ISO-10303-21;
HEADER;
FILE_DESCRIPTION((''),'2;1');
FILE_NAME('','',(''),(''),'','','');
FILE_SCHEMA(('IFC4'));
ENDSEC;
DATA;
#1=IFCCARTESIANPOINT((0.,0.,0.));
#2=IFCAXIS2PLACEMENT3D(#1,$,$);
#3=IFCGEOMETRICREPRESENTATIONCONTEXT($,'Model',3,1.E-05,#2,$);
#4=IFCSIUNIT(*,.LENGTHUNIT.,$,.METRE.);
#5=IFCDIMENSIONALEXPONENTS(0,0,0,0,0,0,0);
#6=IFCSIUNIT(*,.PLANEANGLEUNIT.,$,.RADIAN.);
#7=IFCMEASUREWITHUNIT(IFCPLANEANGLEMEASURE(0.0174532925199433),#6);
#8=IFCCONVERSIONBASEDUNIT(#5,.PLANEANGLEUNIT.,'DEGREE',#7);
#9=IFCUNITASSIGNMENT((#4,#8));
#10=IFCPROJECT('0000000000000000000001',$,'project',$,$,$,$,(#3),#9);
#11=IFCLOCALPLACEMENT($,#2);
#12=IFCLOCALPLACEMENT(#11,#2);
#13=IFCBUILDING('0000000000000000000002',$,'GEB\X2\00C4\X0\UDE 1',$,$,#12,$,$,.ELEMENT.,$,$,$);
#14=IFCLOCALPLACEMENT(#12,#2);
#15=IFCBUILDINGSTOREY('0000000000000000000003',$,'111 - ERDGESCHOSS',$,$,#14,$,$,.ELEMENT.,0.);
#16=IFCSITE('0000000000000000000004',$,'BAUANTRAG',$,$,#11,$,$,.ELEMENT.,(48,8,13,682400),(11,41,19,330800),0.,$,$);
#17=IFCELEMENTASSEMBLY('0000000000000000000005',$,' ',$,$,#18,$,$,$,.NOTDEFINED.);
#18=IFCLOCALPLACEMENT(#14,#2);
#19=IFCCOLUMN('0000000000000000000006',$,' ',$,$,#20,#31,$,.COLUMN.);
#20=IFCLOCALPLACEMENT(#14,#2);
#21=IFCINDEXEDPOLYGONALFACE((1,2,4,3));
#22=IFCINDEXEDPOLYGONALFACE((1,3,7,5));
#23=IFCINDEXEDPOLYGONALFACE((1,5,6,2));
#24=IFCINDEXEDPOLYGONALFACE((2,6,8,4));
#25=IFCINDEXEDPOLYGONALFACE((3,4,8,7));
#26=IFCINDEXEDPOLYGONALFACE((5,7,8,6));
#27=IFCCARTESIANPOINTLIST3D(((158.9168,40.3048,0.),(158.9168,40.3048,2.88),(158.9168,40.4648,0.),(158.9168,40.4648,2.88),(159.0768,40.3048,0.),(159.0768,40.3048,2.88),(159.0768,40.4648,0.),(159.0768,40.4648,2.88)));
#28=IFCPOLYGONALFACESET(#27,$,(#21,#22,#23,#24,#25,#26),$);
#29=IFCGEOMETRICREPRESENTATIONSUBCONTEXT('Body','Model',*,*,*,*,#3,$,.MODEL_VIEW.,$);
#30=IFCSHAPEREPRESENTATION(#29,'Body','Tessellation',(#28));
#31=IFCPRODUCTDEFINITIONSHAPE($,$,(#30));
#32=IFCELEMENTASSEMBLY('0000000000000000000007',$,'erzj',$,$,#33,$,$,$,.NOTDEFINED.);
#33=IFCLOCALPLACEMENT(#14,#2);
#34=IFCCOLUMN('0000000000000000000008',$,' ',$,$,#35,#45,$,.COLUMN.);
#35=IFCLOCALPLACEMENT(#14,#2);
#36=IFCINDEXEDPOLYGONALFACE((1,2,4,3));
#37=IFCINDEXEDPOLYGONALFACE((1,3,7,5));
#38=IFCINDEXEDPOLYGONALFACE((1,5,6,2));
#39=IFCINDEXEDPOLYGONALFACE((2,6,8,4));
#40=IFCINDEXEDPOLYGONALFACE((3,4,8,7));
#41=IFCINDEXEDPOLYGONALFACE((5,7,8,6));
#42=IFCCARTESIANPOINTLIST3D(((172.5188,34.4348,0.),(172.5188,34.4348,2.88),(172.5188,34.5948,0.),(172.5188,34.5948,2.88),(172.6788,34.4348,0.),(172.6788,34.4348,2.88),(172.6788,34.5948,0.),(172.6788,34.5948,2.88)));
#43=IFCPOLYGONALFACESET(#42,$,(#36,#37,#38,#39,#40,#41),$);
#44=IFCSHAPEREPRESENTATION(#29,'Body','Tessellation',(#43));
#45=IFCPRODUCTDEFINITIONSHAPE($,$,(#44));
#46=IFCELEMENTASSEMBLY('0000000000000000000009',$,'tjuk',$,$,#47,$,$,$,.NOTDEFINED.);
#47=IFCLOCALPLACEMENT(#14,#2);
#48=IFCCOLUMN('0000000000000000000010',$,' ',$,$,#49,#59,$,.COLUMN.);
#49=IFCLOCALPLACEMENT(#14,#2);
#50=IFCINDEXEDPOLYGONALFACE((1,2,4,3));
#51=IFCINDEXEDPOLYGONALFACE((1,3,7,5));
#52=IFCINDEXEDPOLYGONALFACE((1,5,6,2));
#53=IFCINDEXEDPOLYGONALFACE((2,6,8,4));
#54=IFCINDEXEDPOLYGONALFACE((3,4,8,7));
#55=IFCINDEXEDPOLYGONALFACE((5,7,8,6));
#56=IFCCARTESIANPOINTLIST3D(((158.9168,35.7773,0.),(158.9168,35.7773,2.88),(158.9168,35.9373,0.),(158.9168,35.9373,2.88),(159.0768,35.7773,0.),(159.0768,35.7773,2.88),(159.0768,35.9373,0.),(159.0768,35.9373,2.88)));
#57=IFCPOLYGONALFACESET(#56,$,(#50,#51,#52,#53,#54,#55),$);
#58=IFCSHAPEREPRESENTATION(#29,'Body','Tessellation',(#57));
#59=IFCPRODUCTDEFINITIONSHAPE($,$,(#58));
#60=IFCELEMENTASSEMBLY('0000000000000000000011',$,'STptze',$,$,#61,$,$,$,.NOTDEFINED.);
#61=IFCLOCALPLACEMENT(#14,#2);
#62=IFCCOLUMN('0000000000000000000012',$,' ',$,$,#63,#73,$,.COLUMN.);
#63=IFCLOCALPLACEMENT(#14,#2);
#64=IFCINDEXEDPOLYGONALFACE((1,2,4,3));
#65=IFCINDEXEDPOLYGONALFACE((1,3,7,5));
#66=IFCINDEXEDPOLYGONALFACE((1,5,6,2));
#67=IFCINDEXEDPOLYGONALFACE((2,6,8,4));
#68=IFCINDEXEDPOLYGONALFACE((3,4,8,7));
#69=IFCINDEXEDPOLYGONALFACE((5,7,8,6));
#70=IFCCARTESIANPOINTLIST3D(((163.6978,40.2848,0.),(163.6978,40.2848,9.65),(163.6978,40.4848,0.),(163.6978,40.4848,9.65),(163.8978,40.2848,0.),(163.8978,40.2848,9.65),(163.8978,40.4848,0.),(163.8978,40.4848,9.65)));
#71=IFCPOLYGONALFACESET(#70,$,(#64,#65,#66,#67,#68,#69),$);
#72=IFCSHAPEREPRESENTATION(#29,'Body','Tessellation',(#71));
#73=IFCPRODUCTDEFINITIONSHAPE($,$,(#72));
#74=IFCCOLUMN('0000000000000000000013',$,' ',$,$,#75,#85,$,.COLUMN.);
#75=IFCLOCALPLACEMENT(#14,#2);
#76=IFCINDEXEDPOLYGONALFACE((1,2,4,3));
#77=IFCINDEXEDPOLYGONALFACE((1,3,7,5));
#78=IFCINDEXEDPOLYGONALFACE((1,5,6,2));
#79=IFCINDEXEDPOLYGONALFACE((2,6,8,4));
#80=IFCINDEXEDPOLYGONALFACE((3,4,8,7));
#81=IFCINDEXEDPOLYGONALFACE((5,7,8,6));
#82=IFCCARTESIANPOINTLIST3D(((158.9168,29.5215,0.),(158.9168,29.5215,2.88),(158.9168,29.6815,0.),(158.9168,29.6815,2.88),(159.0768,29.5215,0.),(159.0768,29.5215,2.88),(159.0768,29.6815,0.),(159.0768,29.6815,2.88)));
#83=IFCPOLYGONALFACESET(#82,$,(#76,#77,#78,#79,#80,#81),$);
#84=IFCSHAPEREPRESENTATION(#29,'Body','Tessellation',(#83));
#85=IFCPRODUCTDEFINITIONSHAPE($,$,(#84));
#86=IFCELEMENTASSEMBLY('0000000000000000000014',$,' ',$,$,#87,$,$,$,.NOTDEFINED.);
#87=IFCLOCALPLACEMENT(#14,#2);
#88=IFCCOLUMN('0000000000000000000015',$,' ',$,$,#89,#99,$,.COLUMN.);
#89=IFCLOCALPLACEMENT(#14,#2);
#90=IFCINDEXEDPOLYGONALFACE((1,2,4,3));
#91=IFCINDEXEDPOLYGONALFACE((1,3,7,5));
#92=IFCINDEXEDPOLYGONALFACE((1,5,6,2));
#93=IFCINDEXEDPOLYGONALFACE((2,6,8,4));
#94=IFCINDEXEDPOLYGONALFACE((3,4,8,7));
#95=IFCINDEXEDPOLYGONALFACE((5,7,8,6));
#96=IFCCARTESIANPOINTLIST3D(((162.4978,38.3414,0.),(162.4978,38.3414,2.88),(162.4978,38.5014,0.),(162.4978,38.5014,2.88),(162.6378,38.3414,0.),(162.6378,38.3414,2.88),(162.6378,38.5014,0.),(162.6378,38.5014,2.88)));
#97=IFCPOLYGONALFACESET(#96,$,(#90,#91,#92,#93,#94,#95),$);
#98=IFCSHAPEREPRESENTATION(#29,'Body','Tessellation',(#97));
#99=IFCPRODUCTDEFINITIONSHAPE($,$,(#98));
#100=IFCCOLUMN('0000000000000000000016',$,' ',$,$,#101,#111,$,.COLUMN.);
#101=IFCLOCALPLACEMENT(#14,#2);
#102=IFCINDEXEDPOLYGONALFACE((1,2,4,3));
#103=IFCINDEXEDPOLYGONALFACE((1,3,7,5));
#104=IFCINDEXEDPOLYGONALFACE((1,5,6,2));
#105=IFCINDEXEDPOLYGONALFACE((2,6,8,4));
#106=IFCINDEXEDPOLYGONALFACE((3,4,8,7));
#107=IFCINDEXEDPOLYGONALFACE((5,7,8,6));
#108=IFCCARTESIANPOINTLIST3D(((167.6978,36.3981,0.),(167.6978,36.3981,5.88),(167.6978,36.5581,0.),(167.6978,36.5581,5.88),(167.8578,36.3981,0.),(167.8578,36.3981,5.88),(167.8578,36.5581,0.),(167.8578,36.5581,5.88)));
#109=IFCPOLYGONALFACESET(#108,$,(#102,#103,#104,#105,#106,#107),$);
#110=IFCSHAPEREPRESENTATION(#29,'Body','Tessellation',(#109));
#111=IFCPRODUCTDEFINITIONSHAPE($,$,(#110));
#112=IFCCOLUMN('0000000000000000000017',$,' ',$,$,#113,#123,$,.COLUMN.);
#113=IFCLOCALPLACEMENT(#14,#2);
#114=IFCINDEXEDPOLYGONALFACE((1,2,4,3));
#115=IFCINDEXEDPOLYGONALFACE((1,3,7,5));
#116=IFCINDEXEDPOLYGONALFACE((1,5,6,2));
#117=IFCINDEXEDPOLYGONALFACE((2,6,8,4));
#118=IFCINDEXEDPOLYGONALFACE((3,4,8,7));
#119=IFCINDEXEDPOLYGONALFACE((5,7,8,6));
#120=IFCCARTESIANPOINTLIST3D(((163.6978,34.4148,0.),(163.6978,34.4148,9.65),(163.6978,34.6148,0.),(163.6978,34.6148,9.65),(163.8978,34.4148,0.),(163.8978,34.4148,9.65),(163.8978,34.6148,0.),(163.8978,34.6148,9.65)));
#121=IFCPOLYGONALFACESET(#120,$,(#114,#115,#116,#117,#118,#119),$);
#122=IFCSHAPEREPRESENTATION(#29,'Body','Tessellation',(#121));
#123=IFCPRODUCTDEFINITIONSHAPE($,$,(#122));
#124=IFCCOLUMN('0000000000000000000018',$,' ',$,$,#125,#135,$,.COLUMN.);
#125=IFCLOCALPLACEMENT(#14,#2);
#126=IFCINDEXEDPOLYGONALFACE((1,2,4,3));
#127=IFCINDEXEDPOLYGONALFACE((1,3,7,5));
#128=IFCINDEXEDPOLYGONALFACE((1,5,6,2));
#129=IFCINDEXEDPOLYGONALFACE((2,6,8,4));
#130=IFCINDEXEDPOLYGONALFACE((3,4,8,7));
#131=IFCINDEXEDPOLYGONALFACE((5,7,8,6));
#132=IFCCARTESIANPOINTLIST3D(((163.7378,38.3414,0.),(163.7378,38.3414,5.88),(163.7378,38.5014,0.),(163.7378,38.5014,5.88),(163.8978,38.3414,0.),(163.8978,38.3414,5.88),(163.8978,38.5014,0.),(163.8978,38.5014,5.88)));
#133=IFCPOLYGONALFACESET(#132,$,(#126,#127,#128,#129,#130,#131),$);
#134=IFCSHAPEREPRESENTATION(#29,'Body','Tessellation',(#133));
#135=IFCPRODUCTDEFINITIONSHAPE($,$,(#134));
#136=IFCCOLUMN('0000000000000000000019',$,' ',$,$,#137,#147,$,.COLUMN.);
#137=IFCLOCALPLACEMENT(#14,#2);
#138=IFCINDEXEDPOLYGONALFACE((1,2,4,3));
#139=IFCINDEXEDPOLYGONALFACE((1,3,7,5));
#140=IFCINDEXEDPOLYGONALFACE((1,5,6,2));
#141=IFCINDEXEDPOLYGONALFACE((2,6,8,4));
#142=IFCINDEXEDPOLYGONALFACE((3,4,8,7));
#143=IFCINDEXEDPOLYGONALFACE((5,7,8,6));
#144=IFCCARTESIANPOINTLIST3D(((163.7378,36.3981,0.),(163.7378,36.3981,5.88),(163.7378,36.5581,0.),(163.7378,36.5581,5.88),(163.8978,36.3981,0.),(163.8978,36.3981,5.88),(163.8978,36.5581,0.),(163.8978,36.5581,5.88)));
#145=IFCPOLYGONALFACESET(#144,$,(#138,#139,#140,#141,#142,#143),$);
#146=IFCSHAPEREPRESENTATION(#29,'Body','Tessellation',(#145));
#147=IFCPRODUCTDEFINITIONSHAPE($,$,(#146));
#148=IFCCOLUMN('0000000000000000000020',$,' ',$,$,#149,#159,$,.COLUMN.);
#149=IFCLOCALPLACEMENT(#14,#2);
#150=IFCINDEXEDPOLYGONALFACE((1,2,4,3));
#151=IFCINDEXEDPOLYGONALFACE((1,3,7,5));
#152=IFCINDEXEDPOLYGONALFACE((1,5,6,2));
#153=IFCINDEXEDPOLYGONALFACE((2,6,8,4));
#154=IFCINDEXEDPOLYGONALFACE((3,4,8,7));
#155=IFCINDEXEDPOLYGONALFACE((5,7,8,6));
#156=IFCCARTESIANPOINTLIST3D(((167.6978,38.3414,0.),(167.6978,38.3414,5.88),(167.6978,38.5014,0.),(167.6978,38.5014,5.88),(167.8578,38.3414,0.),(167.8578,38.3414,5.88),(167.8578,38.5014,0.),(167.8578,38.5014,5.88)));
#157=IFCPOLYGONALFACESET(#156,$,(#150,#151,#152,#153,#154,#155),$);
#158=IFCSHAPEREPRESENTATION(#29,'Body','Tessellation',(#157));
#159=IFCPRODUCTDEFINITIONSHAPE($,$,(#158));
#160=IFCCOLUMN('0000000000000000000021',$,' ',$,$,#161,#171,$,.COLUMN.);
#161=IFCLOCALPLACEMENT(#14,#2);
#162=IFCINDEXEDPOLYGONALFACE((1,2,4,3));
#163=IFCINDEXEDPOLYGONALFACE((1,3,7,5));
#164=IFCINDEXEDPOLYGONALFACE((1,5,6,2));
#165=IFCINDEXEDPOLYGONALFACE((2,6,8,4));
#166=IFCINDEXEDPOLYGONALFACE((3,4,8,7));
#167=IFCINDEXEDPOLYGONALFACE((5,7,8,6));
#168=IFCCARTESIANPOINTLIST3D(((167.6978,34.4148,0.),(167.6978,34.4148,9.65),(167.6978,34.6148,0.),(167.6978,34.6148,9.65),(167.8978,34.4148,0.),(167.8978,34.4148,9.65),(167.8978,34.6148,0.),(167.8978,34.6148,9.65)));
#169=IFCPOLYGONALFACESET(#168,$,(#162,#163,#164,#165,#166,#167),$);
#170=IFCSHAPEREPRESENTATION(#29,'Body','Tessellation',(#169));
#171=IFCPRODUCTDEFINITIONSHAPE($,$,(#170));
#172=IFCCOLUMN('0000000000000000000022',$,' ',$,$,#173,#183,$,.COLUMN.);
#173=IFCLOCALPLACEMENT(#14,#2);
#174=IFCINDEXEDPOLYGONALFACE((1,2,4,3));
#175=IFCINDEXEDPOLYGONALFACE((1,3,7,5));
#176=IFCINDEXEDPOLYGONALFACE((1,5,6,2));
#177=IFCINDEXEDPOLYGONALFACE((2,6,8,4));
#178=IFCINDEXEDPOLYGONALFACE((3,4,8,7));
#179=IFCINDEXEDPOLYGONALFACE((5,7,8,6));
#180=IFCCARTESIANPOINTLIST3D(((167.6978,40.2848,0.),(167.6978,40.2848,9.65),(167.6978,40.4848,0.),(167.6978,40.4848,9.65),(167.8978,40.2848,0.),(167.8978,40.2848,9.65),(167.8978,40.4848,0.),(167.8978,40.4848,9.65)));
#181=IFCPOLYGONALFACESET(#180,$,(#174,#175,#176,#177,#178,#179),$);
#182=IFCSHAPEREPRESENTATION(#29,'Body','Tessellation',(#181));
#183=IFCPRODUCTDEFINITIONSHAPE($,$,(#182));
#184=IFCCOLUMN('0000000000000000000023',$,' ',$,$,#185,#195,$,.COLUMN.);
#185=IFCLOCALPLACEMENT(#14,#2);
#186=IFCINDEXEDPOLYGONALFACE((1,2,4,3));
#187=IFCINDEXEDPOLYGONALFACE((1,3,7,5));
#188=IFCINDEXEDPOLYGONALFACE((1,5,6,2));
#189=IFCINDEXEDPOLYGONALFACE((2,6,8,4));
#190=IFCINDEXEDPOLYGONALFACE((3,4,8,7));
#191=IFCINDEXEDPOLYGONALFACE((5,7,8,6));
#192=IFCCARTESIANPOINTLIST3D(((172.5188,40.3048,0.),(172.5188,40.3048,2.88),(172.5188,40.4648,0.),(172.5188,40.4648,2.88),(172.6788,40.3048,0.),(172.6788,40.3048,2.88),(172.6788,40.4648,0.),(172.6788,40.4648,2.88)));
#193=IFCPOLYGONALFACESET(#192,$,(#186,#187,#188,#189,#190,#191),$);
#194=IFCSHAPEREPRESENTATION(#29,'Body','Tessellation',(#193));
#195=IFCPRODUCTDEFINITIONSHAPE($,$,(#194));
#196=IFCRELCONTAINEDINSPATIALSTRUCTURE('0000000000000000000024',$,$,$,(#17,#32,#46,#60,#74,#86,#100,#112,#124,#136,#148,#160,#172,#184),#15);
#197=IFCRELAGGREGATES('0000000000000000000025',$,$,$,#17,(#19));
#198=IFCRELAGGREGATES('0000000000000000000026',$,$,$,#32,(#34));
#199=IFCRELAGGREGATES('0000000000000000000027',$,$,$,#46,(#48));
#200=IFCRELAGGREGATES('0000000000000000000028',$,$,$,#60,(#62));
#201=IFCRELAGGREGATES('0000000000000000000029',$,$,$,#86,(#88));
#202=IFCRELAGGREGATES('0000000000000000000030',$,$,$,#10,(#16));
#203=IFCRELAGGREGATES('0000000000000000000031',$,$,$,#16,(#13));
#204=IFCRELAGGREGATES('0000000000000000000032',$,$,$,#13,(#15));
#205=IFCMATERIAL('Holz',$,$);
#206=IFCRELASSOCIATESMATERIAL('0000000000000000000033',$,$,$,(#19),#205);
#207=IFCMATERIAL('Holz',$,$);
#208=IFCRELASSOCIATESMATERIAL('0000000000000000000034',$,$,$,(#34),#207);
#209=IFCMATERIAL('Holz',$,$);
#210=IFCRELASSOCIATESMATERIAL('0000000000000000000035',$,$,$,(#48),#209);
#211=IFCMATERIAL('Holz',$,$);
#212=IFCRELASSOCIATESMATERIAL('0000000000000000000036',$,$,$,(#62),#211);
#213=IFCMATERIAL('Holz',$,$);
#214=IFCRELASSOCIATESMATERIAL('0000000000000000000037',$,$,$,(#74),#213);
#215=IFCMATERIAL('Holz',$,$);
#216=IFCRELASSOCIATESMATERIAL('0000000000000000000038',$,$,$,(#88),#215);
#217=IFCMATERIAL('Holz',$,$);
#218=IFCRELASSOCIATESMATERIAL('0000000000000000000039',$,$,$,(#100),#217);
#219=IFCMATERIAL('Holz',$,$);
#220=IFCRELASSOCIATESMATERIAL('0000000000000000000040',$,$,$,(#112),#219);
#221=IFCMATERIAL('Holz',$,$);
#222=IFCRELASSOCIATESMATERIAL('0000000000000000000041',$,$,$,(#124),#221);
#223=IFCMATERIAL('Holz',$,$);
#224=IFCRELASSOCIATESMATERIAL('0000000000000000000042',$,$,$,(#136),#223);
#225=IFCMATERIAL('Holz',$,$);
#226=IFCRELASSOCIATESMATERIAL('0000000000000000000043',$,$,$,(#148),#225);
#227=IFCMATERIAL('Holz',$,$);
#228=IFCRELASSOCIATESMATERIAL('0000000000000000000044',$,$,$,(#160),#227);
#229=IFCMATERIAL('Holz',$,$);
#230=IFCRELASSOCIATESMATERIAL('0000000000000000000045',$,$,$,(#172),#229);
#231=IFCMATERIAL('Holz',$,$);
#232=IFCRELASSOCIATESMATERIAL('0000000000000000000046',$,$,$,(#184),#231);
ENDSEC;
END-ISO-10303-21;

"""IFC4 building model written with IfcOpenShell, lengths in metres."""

from ifc_helpers import new_model, entity, si_unit, converted_unit, frame, origin, origin_with_axes, place, context, subcontext, project, spatial, indexed_curve, outline, extrude, material, element, aggregate, save


model = new_model("IFC4")

# Units and contexts
model_context = context("Model", 3, precision=1e-05, world=origin())
body_context = subcontext(model_context, "Body", "Model", "MODEL_VIEW")
ifc_project = project(units=[si_unit("LENGTHUNIT", "METRE"), converted_unit("PLANEANGLEUNIT", "DEGREE", entity("IfcPlaneAngleMeasure", 0.0174532925199433), si_unit("PLANEANGLEUNIT", "RADIAN"), dimensions=[0, 0, 0, 0, 0, 0, 0])], contexts=[model_context])

# Site, building, storey
site_placement = place(None, origin())
site = spatial("IfcSite", under=ifc_project, at=site_placement, Name="BAUANTRAG", CompositionType="ELEMENT", RefLatitude=(48, 8, 13, 682400), RefLongitude=(11, 41, 19, 330800), RefElevation=0.0)
building_placement = place(site_placement, origin())
building = spatial("IfcBuilding", under=site, at=building_placement, Name="GEBÄUDE 1", CompositionType="ELEMENT")
storey_placement = place(building_placement, origin())
storey = spatial("IfcBuildingStorey", under=building, at=storey_placement, Name="111 - ERDGESCHOSS", CompositionType="ELEMENT", Elevation=0.0)

# Element assemblies, columns
assembly_1_placement = place(storey_placement, origin())
assembly_1 = element("IfcElementAssembly", 1, at=assembly_1_placement, inside=storey, Name=" ", PredefinedType="NOTDEFINED")
ifc_material_1 = material(Name="Holz")
column_1_placement = place(assembly_1_placement, frame((158.9168, 40.3048, 0.0)))
column_1 = element("IfcColumn", 2, at=column_1_placement, material=ifc_material_1, Name=" ", PredefinedType="COLUMN", context=body_context, shape_type="SweptSolid", body=[
    extrude(outline(indexed_curve([(0.0, 0.0), (0.16, 0.0), (0.16, 0.16), (0.0, 0.16), (0.0, 0.0)], self_intersect=False)), origin_with_axes(), (0.0, 0.0, 1.0), 2.88),
])
aggregate(assembly_1, [column_1])
assembly_2_placement = place(storey_placement, origin())
assembly_2 = element("IfcElementAssembly", 3, at=assembly_2_placement, inside=storey, Name="erzj", PredefinedType="NOTDEFINED")
ifc_material_2 = material(Name="Holz")
column_2_placement = place(assembly_2_placement, frame((172.5188, 34.4348, 0.0)))
column_2 = element("IfcColumn", 4, at=column_2_placement, material=ifc_material_2, Name=" ", PredefinedType="COLUMN", context=body_context, shape_type="SweptSolid", body=[
    extrude(outline(indexed_curve([(0.0, 0.0), (0.16, 0.0), (0.16, 0.16), (0.0, 0.16), (0.0, 0.0)], self_intersect=False)), origin_with_axes(), (0.0, 0.0, 1.0), 2.88),
])
aggregate(assembly_2, [column_2])
assembly_3_placement = place(storey_placement, origin())
assembly_3 = element("IfcElementAssembly", 5, at=assembly_3_placement, inside=storey, Name="tjuk", PredefinedType="NOTDEFINED")
ifc_material_3 = material(Name="Holz")
column_3_placement = place(assembly_3_placement, frame((158.9168, 35.7773, 0.0)))
column_3 = element("IfcColumn", 6, at=column_3_placement, material=ifc_material_3, Name=" ", PredefinedType="COLUMN", context=body_context, shape_type="SweptSolid", body=[
    extrude(outline(indexed_curve([(0.0, 0.0), (0.16, 0.0), (0.16, 0.16), (0.0, 0.16), (0.0, 0.0)], self_intersect=False)), origin_with_axes(), (0.0, 0.0, 1.0), 2.88),
])
aggregate(assembly_3, [column_3])
assembly_4_placement = place(storey_placement, origin())
assembly_4 = element("IfcElementAssembly", 7, at=assembly_4_placement, inside=storey, Name="STptze", PredefinedType="NOTDEFINED")
ifc_material_4 = material(Name="Holz")
column_4_placement = place(assembly_4_placement, frame((163.6978, 40.2848, 0.0)))
column_4 = element("IfcColumn", 8, at=column_4_placement, material=ifc_material_4, Name=" ", PredefinedType="COLUMN", context=body_context, shape_type="SweptSolid", body=[
    extrude(outline(indexed_curve([(0.0, 0.0), (0.2, 0.0), (0.2, 0.2), (0.0, 0.2), (0.0, 0.0)], self_intersect=False)), origin_with_axes(), (0.0, 0.0, 1.0), 9.65),
])
aggregate(assembly_4, [column_4])

# Column
ifc_material_5 = material(Name="Holz")
column_5_placement = place(storey_placement, frame((158.9168, 29.5215, 0.0)))
element("IfcColumn", 9, at=column_5_placement, inside=storey, material=ifc_material_5, Name=" ", PredefinedType="COLUMN", context=body_context, shape_type="SweptSolid", body=[
    extrude(outline(indexed_curve([(0.0, 0.0), (0.16, 0.0), (0.16, 0.16), (0.0, 0.16), (0.0, 0.0)], self_intersect=False)), origin_with_axes(), (0.0, 0.0, 1.0), 2.88),
])

# Element assembly, column
assembly_5_placement = place(storey_placement, origin())
assembly_5 = element("IfcElementAssembly", 10, at=assembly_5_placement, inside=storey, Name=" ", PredefinedType="NOTDEFINED")
ifc_material_6 = material(Name="Holz")
column_6_placement = place(assembly_5_placement, frame((162.4978, 38.3414, 0.0)))
column_6 = element("IfcColumn", 11, at=column_6_placement, material=ifc_material_6, Name=" ", PredefinedType="COLUMN", context=body_context, shape_type="SweptSolid", body=[
    extrude(outline(indexed_curve([(0.14, 0.0), (0.14, 0.16), (0.0, 0.16), (0.0, 0.0), (0.14, 0.0)], self_intersect=False)), origin_with_axes(), (0.0, 0.0, 1.0), 2.88),
])
aggregate(assembly_5, [column_6])

# Columns
ifc_material_7 = material(Name="Holz")
column_7_placement = place(storey_placement, frame((167.6978, 36.3981, 0.0)))
element("IfcColumn", 12, at=column_7_placement, inside=storey, material=ifc_material_7, Name=" ", PredefinedType="COLUMN", context=body_context, shape_type="SweptSolid", body=[
    extrude(outline(indexed_curve([(0.0, 0.0), (0.16, 0.0), (0.16, 0.16), (0.0, 0.16), (0.0, 0.0)], self_intersect=False)), origin_with_axes(), (0.0, 0.0, 1.0), 5.88),
])
ifc_material_8 = material(Name="Holz")
column_8_placement = place(storey_placement, frame((163.6978, 34.4148, 0.0)))
element("IfcColumn", 13, at=column_8_placement, inside=storey, material=ifc_material_8, Name=" ", PredefinedType="COLUMN", context=body_context, shape_type="SweptSolid", body=[
    extrude(outline(indexed_curve([(0.0, 0.0), (0.2, 0.0), (0.2, 0.2), (0.0, 0.2), (0.0, 0.0)], self_intersect=False)), origin_with_axes(), (0.0, 0.0, 1.0), 9.65),
])
ifc_material_9 = material(Name="Holz")
column_9_placement = place(storey_placement, frame((163.7378, 38.3414, 0.0)))
element("IfcColumn", 14, at=column_9_placement, inside=storey, material=ifc_material_9, Name=" ", PredefinedType="COLUMN", context=body_context, shape_type="SweptSolid", body=[
    extrude(outline(indexed_curve([(0.0, 0.0), (0.16, 0.0), (0.16, 0.16), (0.0, 0.16), (0.0, 0.0)], self_intersect=False)), origin_with_axes(), (0.0, 0.0, 1.0), 5.88),
])
ifc_material_10 = material(Name="Holz")
column_10_placement = place(storey_placement, frame((163.7378, 36.3981, 0.0)))
element("IfcColumn", 15, at=column_10_placement, inside=storey, material=ifc_material_10, Name=" ", PredefinedType="COLUMN", context=body_context, shape_type="SweptSolid", body=[
    extrude(outline(indexed_curve([(0.0, 0.0), (0.16, 0.0), (0.16, 0.16), (0.0, 0.16), (0.0, 0.0)], self_intersect=False)), origin_with_axes(), (0.0, 0.0, 1.0), 5.88),
])
ifc_material_11 = material(Name="Holz")
column_11_placement = place(storey_placement, frame((167.6978, 38.3414, 0.0)))
element("IfcColumn", 16, at=column_11_placement, inside=storey, material=ifc_material_11, Name=" ", PredefinedType="COLUMN", context=body_context, shape_type="SweptSolid", body=[
    extrude(outline(indexed_curve([(0.0, 0.0), (0.16, 0.0), (0.16, 0.16), (0.0, 0.16), (0.0, 0.0)], self_intersect=False)), origin_with_axes(), (0.0, 0.0, 1.0), 5.88),
])
ifc_material_12 = material(Name="Holz")
column_12_placement = place(storey_placement, frame((167.6978, 34.4148, 0.0)))
element("IfcColumn", 17, at=column_12_placement, inside=storey, material=ifc_material_12, Name=" ", PredefinedType="COLUMN", context=body_context, shape_type="SweptSolid", body=[
    extrude(outline(indexed_curve([(0.0, 0.0), (0.2, 0.0), (0.2, 0.2), (0.0, 0.2), (0.0, 0.0)], self_intersect=False)), origin_with_axes(), (0.0, 0.0, 1.0), 9.65),
])
ifc_material_13 = material(Name="Holz")
column_13_placement = place(storey_placement, frame((167.6978, 40.2848, 0.0)))
element("IfcColumn", 18, at=column_13_placement, inside=storey, material=ifc_material_13, Name=" ", PredefinedType="COLUMN", context=body_context, shape_type="SweptSolid", body=[
    extrude(outline(indexed_curve([(0.0, 0.0), (0.2, 0.0), (0.2, 0.2), (0.0, 0.2), (0.0, 0.0)], self_intersect=False)), origin_with_axes(), (0.0, 0.0, 1.0), 9.65),
])
ifc_material_14 = material(Name="Holz")
column_14_placement = place(storey_placement, frame((172.5188, 40.3048, 0.0)))
element("IfcColumn", 19, at=column_14_placement, inside=storey, material=ifc_material_14, Name=" ", PredefinedType="COLUMN", context=body_context, shape_type="SweptSolid", body=[
    extrude(outline(indexed_curve([(0.0, 0.0), (0.16, 0.0), (0.16, 0.16), (0.0, 0.16), (0.0, 0.0)], self_intersect=False)), origin_with_axes(), (0.0, 0.0, 1.0), 2.88),
])

save(model, "model.ifc")
